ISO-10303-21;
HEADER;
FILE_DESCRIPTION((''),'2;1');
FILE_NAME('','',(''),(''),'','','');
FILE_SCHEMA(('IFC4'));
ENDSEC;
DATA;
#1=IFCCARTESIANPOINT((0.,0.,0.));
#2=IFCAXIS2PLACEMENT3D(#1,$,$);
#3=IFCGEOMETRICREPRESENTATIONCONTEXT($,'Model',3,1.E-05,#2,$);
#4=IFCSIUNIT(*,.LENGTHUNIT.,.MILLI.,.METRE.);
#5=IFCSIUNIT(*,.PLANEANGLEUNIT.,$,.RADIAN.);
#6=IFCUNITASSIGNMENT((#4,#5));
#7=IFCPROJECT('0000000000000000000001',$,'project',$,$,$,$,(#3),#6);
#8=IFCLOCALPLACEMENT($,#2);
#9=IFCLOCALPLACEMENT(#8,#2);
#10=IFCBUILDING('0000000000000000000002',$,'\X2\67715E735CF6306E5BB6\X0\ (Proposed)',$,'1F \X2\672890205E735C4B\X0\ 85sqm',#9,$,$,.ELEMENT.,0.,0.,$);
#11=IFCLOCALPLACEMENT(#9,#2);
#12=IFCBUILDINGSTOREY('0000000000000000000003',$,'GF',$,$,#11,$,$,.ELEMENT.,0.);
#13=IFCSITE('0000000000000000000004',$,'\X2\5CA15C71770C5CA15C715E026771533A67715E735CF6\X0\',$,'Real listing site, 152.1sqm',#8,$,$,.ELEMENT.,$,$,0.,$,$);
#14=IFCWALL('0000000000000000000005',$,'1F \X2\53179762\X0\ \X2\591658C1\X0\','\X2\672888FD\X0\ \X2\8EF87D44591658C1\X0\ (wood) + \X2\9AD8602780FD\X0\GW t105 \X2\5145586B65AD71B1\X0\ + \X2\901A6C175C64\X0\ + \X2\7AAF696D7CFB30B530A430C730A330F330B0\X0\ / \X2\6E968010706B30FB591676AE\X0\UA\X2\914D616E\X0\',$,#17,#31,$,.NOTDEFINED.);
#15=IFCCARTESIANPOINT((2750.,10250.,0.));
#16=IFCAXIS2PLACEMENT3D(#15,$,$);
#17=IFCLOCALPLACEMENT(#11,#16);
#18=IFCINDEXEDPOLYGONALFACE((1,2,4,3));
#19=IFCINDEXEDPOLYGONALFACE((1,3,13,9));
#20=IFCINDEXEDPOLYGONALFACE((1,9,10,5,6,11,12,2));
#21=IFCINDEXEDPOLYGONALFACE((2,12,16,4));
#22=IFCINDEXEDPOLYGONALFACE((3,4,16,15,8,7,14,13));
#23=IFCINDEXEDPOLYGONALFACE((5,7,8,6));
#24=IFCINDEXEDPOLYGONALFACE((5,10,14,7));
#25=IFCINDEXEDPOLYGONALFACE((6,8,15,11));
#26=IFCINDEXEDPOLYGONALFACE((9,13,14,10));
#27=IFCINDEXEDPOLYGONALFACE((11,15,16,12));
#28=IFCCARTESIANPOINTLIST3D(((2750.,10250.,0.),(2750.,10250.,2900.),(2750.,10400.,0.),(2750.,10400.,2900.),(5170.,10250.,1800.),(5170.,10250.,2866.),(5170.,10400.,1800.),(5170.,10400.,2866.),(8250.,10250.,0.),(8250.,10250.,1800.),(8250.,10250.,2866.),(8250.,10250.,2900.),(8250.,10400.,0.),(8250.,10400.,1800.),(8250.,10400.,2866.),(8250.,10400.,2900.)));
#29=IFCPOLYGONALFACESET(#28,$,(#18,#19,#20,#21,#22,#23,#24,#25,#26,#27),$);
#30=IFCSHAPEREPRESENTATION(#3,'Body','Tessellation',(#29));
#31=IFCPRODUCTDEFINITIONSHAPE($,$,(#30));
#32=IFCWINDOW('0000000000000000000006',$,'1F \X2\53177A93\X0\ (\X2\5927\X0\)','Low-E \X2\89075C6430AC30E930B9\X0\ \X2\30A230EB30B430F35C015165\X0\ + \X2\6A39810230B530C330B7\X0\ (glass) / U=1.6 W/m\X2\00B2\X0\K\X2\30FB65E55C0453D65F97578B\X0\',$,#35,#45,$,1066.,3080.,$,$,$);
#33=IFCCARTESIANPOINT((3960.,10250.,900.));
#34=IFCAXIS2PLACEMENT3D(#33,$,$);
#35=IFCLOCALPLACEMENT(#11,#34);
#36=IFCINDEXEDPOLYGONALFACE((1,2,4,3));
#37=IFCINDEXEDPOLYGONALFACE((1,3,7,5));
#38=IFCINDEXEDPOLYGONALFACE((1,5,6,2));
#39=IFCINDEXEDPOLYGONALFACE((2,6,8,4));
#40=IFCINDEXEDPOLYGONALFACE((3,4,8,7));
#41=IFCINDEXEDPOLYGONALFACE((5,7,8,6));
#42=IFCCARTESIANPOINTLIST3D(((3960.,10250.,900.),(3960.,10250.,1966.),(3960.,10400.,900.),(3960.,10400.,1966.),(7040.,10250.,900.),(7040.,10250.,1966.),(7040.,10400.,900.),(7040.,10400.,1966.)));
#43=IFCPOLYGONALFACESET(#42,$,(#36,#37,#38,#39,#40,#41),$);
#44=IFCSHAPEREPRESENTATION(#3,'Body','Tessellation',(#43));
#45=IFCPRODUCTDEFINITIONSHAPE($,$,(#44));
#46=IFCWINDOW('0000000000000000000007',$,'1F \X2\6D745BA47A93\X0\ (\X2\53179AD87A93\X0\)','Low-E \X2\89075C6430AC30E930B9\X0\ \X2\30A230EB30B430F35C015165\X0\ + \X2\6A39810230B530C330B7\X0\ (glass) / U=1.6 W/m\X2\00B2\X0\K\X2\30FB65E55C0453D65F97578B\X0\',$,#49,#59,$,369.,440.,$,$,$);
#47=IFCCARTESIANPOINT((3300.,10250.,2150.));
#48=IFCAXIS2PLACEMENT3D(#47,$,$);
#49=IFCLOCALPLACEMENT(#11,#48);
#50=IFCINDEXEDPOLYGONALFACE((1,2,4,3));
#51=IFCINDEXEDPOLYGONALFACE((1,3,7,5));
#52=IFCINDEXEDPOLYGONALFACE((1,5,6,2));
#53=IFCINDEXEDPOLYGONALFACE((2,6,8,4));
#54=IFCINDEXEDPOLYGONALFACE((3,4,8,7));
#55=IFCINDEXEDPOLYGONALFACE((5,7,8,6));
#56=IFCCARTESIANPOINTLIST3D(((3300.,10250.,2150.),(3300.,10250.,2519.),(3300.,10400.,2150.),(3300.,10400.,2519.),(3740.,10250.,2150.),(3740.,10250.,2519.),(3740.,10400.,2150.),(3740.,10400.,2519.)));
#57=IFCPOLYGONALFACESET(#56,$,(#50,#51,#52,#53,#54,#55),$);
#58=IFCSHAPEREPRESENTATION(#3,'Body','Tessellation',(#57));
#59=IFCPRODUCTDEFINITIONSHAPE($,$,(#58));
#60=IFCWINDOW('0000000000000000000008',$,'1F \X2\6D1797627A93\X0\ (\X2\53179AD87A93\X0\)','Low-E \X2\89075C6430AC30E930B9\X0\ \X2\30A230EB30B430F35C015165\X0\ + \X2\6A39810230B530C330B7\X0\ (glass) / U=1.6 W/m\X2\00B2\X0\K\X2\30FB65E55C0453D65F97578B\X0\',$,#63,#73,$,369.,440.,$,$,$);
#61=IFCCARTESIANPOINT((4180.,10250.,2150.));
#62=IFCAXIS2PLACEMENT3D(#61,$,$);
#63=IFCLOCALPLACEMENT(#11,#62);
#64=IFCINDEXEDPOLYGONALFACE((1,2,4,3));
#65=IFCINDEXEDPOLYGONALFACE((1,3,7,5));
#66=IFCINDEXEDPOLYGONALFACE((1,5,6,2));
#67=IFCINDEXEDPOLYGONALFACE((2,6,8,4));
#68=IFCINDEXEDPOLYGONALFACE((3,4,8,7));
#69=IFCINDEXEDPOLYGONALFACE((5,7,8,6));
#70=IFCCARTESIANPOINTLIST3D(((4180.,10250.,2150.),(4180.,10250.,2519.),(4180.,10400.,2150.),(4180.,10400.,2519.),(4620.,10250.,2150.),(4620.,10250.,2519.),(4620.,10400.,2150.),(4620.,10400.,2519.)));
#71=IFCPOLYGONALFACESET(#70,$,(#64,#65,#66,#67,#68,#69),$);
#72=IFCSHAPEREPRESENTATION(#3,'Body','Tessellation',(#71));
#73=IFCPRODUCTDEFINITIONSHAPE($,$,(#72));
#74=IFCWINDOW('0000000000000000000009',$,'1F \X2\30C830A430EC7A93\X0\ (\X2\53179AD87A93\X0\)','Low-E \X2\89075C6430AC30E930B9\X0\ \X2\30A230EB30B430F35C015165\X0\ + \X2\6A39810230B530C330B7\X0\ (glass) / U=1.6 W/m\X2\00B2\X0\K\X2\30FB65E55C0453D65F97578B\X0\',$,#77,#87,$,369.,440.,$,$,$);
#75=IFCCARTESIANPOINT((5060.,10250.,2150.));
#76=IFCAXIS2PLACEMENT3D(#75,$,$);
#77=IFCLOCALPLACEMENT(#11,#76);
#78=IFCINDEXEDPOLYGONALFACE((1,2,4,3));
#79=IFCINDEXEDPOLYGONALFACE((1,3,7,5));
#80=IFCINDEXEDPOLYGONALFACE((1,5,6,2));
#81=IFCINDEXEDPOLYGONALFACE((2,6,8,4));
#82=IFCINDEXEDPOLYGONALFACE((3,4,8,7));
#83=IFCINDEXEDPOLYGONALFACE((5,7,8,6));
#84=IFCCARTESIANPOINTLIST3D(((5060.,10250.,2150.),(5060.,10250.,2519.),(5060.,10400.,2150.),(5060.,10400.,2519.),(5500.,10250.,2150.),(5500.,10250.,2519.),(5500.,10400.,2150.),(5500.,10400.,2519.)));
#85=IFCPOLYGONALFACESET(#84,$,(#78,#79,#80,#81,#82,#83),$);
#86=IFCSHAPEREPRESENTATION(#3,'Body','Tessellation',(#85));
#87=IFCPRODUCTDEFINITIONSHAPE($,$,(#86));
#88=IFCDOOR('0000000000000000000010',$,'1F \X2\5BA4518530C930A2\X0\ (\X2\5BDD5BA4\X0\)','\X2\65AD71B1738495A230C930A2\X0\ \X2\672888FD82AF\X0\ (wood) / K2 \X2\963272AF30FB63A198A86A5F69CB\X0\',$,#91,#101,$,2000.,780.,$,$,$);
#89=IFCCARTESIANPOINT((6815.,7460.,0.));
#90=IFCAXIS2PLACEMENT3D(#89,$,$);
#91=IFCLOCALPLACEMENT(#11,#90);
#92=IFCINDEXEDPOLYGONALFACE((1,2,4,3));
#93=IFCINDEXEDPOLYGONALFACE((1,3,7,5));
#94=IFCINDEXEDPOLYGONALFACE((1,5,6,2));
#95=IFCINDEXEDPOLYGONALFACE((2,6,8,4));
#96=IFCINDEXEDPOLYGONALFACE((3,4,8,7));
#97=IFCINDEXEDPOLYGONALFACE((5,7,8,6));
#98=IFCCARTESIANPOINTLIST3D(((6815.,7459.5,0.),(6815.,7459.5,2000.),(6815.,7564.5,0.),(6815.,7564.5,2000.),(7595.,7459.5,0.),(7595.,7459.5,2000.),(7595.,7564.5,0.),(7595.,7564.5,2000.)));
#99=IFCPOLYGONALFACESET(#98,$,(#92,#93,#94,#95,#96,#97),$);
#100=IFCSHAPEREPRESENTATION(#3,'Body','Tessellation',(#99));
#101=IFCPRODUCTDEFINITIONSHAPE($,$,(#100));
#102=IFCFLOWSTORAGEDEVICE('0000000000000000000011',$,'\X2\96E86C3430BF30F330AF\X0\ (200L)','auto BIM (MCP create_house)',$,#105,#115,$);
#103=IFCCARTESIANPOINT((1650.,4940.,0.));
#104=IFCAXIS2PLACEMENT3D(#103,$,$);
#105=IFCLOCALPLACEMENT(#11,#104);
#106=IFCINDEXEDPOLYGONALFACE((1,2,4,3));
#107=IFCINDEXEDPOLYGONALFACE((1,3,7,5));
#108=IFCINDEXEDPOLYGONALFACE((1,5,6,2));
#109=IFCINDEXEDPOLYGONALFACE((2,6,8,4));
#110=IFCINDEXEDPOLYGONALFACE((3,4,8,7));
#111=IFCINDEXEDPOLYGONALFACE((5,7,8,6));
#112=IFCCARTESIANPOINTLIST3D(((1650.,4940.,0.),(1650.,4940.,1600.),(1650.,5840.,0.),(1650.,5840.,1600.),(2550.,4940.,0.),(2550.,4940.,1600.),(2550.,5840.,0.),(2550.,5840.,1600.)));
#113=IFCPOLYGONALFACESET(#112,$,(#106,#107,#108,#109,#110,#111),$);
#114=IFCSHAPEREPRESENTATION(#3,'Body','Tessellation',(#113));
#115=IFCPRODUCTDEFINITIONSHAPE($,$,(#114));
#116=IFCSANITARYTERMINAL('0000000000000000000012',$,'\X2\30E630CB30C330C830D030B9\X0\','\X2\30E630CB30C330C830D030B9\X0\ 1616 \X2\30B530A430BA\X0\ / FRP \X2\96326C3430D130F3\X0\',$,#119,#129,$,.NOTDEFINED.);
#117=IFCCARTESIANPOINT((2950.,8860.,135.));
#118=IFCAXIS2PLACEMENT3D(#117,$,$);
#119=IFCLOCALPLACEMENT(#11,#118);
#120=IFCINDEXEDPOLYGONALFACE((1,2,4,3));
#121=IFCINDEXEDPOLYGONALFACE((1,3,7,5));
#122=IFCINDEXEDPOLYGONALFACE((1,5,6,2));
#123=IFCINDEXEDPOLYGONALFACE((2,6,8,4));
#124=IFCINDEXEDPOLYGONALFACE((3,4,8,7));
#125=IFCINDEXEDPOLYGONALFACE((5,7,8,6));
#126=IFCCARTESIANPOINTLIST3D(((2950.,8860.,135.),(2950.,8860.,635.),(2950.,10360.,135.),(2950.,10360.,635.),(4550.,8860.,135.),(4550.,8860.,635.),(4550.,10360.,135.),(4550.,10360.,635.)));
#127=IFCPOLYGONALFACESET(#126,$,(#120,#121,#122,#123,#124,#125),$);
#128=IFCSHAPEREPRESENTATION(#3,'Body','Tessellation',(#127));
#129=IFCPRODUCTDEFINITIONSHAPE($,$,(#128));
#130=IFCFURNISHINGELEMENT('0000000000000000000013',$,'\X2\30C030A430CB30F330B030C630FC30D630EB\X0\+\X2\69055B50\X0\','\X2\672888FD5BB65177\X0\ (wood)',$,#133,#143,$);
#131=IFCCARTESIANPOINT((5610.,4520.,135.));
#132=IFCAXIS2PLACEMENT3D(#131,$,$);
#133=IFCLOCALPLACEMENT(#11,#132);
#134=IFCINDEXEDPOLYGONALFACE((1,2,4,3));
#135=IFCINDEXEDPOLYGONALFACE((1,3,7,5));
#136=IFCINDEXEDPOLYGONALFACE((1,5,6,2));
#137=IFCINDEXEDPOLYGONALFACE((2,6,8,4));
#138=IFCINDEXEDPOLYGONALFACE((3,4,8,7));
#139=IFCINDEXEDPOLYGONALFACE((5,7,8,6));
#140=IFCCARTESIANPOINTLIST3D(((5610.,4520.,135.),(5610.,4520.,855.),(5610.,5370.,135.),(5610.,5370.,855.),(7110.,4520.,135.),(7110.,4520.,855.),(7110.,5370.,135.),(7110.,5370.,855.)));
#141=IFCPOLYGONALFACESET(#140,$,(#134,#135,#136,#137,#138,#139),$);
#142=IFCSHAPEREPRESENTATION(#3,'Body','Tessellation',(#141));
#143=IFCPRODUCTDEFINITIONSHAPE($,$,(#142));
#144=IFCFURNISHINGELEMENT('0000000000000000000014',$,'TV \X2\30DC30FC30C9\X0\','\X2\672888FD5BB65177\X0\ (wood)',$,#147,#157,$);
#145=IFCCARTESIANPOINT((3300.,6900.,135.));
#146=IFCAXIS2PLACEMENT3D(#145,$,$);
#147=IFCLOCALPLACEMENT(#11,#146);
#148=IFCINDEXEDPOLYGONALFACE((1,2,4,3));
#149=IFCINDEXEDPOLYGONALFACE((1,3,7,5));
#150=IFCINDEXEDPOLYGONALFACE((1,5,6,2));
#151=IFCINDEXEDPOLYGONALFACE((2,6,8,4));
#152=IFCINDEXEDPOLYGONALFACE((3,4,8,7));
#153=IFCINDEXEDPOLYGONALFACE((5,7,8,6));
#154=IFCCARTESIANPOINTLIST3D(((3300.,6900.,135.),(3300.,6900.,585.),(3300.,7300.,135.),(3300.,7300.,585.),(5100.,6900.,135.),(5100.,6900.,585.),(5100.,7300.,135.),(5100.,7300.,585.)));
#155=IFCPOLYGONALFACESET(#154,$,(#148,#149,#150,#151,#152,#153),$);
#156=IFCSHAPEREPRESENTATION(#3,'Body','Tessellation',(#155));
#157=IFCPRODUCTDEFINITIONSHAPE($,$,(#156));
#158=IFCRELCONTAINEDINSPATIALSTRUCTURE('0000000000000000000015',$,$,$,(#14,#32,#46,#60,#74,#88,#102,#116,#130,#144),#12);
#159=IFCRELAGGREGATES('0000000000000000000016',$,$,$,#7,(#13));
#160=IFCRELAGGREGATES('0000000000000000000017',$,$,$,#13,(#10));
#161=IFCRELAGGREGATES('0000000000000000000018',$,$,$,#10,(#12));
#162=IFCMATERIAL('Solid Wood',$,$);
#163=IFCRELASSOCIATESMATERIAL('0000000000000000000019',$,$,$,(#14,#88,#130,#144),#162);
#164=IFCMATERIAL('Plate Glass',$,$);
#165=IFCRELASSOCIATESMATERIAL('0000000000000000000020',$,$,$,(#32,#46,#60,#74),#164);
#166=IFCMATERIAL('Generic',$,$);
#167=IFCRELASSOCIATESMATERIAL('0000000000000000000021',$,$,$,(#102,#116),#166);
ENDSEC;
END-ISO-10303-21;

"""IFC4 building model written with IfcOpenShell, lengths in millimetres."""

from ifc_helpers import new_model, si_unit, frame, frame_2d, origin, place, context, project, spatial, rectangle, extrude, material, element, fill, save


model = new_model("IFC4")

# Units and contexts
model_context = context("Model", 3, precision=1e-05, world=origin())
ifc_project = project(units=[si_unit("LENGTHUNIT", "METRE", prefix="MILLI"), si_unit("PLANEANGLEUNIT", "RADIAN")], contexts=[model_context])

# Site, building, storey
site_placement = place(None, origin())
site = spatial("IfcSite", under=ifc_project, at=site_placement, Name="岡山県岡山市東区東平島", ObjectType="Real listing site, 152.1sqm", CompositionType="ELEMENT", RefElevation=0.0)
building_placement = place(site_placement, origin())
building = spatial("IfcBuilding", under=site, at=building_placement, Name="東平島の家 (Proposed)", ObjectType="1F 木造平屋 85sqm", CompositionType="ELEMENT", ElevationOfRefHeight=0.0, ElevationOfTerrain=0.0)
storey_placement = place(building_placement, origin())
storey = spatial("IfcBuildingStorey", under=building, at=storey_placement, Name="GF", CompositionType="ELEMENT", Elevation=0.0)

# Wall, openings, windows
ifc_material_1 = material(Name="Solid Wood")
wall_1_placement = place(storey_placement, frame((2750.0, 10250.0, 0.0)))
wall_1 = element("IfcWall", 1, at=wall_1_placement, inside=storey, material=ifc_material_1, Name="1F 北面 外壁", Description="木製 軸組外壁 (wood) + 高性能GW t105 充填断熱 + 通気層 + 窯業系サイディング / 準耐火・外皮UA配慮", PredefinedType="NOTDEFINED", context=model_context, shape_type="SweptSolid", body=[
    extrude(rectangle(XDim=5500.0, YDim=150.0, at=frame_2d((2750.0, 75.0))), frame((2750.0, 10250.0, 0.0)), (0.0, 0.0, 1.0), 2900.0),
])
opening_1_placement = place(storey_placement, frame((3960.0, 10250.0, 900.0)))
opening_1 = element("IfcOpeningElement", 2, at=opening_1_placement, cuts=wall_1, PredefinedType="NOTDEFINED", context=model_context, shape_type="SweptSolid", body=[
    extrude(rectangle(XDim=3080.0, YDim=150.0, at=frame_2d((1540.0, 75.0))), frame((3960.0, 10250.0, 900.0)), (0.0, 0.0, 1.0), 1066.0),
])
opening_2_placement = place(storey_placement, frame((3300.0, 10250.0, 2150.0)))
opening_2 = element("IfcOpeningElement", 3, at=opening_2_placement, cuts=wall_1, PredefinedType="NOTDEFINED", context=model_context, shape_type="SweptSolid", body=[
    extrude(rectangle(XDim=440.0, YDim=150.0, at=frame_2d((220.0, 75.0))), frame((3300.0, 10250.0, 2150.0)), (0.0, 0.0, 1.0), 369.0),
])
opening_3_placement = place(storey_placement, frame((4180.0, 10250.0, 2150.0)))
opening_3 = element("IfcOpeningElement", 4, at=opening_3_placement, cuts=wall_1, PredefinedType="NOTDEFINED", context=model_context, shape_type="SweptSolid", body=[
    extrude(rectangle(XDim=440.0, YDim=150.0, at=frame_2d((220.0, 75.0))), frame((4180.0, 10250.0, 2150.0)), (0.0, 0.0, 1.0), 369.0),
])
opening_4_placement = place(storey_placement, frame((5060.0, 10250.0, 2150.0)))
opening_4 = element("IfcOpeningElement", 5, at=opening_4_placement, cuts=wall_1, PredefinedType="NOTDEFINED", context=model_context, shape_type="SweptSolid", body=[
    extrude(rectangle(XDim=440.0, YDim=150.0, at=frame_2d((220.0, 75.0))), frame((5060.0, 10250.0, 2150.0)), (0.0, 0.0, 1.0), 369.0),
])
ifc_material_2 = material(Name="Plate Glass")
window_1_placement = place(storey_placement, frame((3960.0, 10250.0, 900.0)))
window_1 = element("IfcWindow", 6, at=window_1_placement, inside=storey, material=ifc_material_2, Name="1F 北窓 (大)", Description="Low-E 複層ガラス アルゴン封入 + 樹脂サッシ (glass) / U=1.6 W/m²K・日射取得型", OverallHeight=1066.0, OverallWidth=3080.0, context=model_context, shape_type="SweptSolid", body=[
    extrude(rectangle(XDim=3080.0, YDim=150.0, at=frame_2d((1540.0, 75.0))), frame((3960.0, 10250.0, 900.0)), (0.0, 0.0, 1.0), 1066.0),
])
fill(opening_1, window_1)
window_2_placement = place(storey_placement, frame((3300.0, 10250.0, 2150.0)))
window_2 = element("IfcWindow", 7, at=window_2_placement, inside=storey, material=ifc_material_2, Name="1F 浴室窓 (北高窓)", Description="Low-E 複層ガラス アルゴン封入 + 樹脂サッシ (glass) / U=1.6 W/m²K・日射取得型", OverallHeight=369.0, OverallWidth=440.0, context=model_context, shape_type="SweptSolid", body=[
    extrude(rectangle(XDim=440.0, YDim=150.0, at=frame_2d((220.0, 75.0))), frame((3300.0, 10250.0, 2150.0)), (0.0, 0.0, 1.0), 369.0),
])
fill(opening_2, window_2)
window_3_placement = place(storey_placement, frame((4180.0, 10250.0, 2150.0)))
window_3 = element("IfcWindow", 8, at=window_3_placement, inside=storey, material=ifc_material_2, Name="1F 洗面窓 (北高窓)", Description="Low-E 複層ガラス アルゴン封入 + 樹脂サッシ (glass) / U=1.6 W/m²K・日射取得型", OverallHeight=369.0, OverallWidth=440.0, context=model_context, shape_type="SweptSolid", body=[
    extrude(rectangle(XDim=440.0, YDim=150.0, at=frame_2d((220.0, 75.0))), frame((4180.0, 10250.0, 2150.0)), (0.0, 0.0, 1.0), 369.0),
])
fill(opening_3, window_3)
window_4_placement = place(storey_placement, frame((5060.0, 10250.0, 2150.0)))
window_4 = element("IfcWindow", 9, at=window_4_placement, inside=storey, material=ifc_material_2, Name="1F トイレ窓 (北高窓)", Description="Low-E 複層ガラス アルゴン封入 + 樹脂サッシ (glass) / U=1.6 W/m²K・日射取得型", OverallHeight=369.0, OverallWidth=440.0, context=model_context, shape_type="SweptSolid", body=[
    extrude(rectangle(XDim=440.0, YDim=150.0, at=frame_2d((220.0, 75.0))), frame((5060.0, 10250.0, 2150.0)), (0.0, 0.0, 1.0), 369.0),
])
fill(opening_4, window_4)

# Door
door_1_placement = place(storey_placement, frame((6815.0, 7460.0, 0.0)))
element("IfcDoor", 10, at=door_1_placement, inside=storey, material=ifc_material_1, Name="1F 室内ドア (寝室)", Description="断熱玄関ドア 木製芯 (wood) / K2 防犯・採風機構", OverallHeight=2000.0, OverallWidth=780.0, context=model_context, shape_type="SweptSolid", body=[
    extrude(rectangle(XDim=780.0, YDim=105.0, at=frame_2d((390.0, 52.0))), frame((6815.0, 7460.0, 0.0)), (0.0, 0.0, 1.0), 2000.0),
])

# Flow storage device
ifc_material_3 = material(Name="Generic")
flow_storage_device_placement = place(storey_placement, frame((1650.0, 4940.0, 0.0)))
element("IfcFlowStorageDevice", 11, at=flow_storage_device_placement, inside=storey, material=ifc_material_3, Name="雨水タンク (200L)", Description="auto BIM (MCP create_house)", context=model_context, shape_type="SweptSolid", body=[
    extrude(rectangle(XDim=900.0, YDim=900.0, at=frame_2d((450.0, 450.0))), frame((1650.0, 4940.0, 0.0)), (0.0, 0.0, 1.0), 1600.0),
])

# Sanitary terminal
sanitary_terminal_placement = place(storey_placement, frame((2950.0, 8860.0, 135.0)))
element("IfcSanitaryTerminal", 12, at=sanitary_terminal_placement, inside=storey, material=ifc_material_3, Name="ユニットバス", Description="ユニットバス 1616 サイズ / FRP 防水パン", PredefinedType="NOTDEFINED", context=model_context, shape_type="SweptSolid", body=[
    extrude(rectangle(XDim=1600.0, YDim=1500.0, at=frame_2d((800.0, 750.0))), frame((2950.0, 8860.0, 135.0)), (0.0, 0.0, 1.0), 500.0),
])

# Furnishing elements
furnishing_1_placement = place(storey_placement, frame((5610.0, 4520.0, 135.0)))
element("IfcFurnishingElement", 13, at=furnishing_1_placement, inside=storey, material=ifc_material_1, Name="ダイニングテーブル+椅子", Description="木製家具 (wood)", context=model_context, shape_type="SweptSolid", body=[
    extrude(rectangle(XDim=1500.0, YDim=850.0, at=frame_2d((750.0, 425.0))), frame((5610.0, 4520.0, 135.0)), (0.0, 0.0, 1.0), 720.0),
])
furnishing_2_placement = place(storey_placement, frame((3300.0, 6900.0, 135.0)))
element("IfcFurnishingElement", 14, at=furnishing_2_placement, inside=storey, material=ifc_material_1, Name="TV ボード", Description="木製家具 (wood)", context=model_context, shape_type="SweptSolid", body=[
    extrude(rectangle(XDim=1800.0, YDim=400.0, at=frame_2d((900.0, 200.0))), frame((3300.0, 6900.0, 135.0)), (0.0, 0.0, 1.0), 450.0),
])

save(model, "model.ifc")
